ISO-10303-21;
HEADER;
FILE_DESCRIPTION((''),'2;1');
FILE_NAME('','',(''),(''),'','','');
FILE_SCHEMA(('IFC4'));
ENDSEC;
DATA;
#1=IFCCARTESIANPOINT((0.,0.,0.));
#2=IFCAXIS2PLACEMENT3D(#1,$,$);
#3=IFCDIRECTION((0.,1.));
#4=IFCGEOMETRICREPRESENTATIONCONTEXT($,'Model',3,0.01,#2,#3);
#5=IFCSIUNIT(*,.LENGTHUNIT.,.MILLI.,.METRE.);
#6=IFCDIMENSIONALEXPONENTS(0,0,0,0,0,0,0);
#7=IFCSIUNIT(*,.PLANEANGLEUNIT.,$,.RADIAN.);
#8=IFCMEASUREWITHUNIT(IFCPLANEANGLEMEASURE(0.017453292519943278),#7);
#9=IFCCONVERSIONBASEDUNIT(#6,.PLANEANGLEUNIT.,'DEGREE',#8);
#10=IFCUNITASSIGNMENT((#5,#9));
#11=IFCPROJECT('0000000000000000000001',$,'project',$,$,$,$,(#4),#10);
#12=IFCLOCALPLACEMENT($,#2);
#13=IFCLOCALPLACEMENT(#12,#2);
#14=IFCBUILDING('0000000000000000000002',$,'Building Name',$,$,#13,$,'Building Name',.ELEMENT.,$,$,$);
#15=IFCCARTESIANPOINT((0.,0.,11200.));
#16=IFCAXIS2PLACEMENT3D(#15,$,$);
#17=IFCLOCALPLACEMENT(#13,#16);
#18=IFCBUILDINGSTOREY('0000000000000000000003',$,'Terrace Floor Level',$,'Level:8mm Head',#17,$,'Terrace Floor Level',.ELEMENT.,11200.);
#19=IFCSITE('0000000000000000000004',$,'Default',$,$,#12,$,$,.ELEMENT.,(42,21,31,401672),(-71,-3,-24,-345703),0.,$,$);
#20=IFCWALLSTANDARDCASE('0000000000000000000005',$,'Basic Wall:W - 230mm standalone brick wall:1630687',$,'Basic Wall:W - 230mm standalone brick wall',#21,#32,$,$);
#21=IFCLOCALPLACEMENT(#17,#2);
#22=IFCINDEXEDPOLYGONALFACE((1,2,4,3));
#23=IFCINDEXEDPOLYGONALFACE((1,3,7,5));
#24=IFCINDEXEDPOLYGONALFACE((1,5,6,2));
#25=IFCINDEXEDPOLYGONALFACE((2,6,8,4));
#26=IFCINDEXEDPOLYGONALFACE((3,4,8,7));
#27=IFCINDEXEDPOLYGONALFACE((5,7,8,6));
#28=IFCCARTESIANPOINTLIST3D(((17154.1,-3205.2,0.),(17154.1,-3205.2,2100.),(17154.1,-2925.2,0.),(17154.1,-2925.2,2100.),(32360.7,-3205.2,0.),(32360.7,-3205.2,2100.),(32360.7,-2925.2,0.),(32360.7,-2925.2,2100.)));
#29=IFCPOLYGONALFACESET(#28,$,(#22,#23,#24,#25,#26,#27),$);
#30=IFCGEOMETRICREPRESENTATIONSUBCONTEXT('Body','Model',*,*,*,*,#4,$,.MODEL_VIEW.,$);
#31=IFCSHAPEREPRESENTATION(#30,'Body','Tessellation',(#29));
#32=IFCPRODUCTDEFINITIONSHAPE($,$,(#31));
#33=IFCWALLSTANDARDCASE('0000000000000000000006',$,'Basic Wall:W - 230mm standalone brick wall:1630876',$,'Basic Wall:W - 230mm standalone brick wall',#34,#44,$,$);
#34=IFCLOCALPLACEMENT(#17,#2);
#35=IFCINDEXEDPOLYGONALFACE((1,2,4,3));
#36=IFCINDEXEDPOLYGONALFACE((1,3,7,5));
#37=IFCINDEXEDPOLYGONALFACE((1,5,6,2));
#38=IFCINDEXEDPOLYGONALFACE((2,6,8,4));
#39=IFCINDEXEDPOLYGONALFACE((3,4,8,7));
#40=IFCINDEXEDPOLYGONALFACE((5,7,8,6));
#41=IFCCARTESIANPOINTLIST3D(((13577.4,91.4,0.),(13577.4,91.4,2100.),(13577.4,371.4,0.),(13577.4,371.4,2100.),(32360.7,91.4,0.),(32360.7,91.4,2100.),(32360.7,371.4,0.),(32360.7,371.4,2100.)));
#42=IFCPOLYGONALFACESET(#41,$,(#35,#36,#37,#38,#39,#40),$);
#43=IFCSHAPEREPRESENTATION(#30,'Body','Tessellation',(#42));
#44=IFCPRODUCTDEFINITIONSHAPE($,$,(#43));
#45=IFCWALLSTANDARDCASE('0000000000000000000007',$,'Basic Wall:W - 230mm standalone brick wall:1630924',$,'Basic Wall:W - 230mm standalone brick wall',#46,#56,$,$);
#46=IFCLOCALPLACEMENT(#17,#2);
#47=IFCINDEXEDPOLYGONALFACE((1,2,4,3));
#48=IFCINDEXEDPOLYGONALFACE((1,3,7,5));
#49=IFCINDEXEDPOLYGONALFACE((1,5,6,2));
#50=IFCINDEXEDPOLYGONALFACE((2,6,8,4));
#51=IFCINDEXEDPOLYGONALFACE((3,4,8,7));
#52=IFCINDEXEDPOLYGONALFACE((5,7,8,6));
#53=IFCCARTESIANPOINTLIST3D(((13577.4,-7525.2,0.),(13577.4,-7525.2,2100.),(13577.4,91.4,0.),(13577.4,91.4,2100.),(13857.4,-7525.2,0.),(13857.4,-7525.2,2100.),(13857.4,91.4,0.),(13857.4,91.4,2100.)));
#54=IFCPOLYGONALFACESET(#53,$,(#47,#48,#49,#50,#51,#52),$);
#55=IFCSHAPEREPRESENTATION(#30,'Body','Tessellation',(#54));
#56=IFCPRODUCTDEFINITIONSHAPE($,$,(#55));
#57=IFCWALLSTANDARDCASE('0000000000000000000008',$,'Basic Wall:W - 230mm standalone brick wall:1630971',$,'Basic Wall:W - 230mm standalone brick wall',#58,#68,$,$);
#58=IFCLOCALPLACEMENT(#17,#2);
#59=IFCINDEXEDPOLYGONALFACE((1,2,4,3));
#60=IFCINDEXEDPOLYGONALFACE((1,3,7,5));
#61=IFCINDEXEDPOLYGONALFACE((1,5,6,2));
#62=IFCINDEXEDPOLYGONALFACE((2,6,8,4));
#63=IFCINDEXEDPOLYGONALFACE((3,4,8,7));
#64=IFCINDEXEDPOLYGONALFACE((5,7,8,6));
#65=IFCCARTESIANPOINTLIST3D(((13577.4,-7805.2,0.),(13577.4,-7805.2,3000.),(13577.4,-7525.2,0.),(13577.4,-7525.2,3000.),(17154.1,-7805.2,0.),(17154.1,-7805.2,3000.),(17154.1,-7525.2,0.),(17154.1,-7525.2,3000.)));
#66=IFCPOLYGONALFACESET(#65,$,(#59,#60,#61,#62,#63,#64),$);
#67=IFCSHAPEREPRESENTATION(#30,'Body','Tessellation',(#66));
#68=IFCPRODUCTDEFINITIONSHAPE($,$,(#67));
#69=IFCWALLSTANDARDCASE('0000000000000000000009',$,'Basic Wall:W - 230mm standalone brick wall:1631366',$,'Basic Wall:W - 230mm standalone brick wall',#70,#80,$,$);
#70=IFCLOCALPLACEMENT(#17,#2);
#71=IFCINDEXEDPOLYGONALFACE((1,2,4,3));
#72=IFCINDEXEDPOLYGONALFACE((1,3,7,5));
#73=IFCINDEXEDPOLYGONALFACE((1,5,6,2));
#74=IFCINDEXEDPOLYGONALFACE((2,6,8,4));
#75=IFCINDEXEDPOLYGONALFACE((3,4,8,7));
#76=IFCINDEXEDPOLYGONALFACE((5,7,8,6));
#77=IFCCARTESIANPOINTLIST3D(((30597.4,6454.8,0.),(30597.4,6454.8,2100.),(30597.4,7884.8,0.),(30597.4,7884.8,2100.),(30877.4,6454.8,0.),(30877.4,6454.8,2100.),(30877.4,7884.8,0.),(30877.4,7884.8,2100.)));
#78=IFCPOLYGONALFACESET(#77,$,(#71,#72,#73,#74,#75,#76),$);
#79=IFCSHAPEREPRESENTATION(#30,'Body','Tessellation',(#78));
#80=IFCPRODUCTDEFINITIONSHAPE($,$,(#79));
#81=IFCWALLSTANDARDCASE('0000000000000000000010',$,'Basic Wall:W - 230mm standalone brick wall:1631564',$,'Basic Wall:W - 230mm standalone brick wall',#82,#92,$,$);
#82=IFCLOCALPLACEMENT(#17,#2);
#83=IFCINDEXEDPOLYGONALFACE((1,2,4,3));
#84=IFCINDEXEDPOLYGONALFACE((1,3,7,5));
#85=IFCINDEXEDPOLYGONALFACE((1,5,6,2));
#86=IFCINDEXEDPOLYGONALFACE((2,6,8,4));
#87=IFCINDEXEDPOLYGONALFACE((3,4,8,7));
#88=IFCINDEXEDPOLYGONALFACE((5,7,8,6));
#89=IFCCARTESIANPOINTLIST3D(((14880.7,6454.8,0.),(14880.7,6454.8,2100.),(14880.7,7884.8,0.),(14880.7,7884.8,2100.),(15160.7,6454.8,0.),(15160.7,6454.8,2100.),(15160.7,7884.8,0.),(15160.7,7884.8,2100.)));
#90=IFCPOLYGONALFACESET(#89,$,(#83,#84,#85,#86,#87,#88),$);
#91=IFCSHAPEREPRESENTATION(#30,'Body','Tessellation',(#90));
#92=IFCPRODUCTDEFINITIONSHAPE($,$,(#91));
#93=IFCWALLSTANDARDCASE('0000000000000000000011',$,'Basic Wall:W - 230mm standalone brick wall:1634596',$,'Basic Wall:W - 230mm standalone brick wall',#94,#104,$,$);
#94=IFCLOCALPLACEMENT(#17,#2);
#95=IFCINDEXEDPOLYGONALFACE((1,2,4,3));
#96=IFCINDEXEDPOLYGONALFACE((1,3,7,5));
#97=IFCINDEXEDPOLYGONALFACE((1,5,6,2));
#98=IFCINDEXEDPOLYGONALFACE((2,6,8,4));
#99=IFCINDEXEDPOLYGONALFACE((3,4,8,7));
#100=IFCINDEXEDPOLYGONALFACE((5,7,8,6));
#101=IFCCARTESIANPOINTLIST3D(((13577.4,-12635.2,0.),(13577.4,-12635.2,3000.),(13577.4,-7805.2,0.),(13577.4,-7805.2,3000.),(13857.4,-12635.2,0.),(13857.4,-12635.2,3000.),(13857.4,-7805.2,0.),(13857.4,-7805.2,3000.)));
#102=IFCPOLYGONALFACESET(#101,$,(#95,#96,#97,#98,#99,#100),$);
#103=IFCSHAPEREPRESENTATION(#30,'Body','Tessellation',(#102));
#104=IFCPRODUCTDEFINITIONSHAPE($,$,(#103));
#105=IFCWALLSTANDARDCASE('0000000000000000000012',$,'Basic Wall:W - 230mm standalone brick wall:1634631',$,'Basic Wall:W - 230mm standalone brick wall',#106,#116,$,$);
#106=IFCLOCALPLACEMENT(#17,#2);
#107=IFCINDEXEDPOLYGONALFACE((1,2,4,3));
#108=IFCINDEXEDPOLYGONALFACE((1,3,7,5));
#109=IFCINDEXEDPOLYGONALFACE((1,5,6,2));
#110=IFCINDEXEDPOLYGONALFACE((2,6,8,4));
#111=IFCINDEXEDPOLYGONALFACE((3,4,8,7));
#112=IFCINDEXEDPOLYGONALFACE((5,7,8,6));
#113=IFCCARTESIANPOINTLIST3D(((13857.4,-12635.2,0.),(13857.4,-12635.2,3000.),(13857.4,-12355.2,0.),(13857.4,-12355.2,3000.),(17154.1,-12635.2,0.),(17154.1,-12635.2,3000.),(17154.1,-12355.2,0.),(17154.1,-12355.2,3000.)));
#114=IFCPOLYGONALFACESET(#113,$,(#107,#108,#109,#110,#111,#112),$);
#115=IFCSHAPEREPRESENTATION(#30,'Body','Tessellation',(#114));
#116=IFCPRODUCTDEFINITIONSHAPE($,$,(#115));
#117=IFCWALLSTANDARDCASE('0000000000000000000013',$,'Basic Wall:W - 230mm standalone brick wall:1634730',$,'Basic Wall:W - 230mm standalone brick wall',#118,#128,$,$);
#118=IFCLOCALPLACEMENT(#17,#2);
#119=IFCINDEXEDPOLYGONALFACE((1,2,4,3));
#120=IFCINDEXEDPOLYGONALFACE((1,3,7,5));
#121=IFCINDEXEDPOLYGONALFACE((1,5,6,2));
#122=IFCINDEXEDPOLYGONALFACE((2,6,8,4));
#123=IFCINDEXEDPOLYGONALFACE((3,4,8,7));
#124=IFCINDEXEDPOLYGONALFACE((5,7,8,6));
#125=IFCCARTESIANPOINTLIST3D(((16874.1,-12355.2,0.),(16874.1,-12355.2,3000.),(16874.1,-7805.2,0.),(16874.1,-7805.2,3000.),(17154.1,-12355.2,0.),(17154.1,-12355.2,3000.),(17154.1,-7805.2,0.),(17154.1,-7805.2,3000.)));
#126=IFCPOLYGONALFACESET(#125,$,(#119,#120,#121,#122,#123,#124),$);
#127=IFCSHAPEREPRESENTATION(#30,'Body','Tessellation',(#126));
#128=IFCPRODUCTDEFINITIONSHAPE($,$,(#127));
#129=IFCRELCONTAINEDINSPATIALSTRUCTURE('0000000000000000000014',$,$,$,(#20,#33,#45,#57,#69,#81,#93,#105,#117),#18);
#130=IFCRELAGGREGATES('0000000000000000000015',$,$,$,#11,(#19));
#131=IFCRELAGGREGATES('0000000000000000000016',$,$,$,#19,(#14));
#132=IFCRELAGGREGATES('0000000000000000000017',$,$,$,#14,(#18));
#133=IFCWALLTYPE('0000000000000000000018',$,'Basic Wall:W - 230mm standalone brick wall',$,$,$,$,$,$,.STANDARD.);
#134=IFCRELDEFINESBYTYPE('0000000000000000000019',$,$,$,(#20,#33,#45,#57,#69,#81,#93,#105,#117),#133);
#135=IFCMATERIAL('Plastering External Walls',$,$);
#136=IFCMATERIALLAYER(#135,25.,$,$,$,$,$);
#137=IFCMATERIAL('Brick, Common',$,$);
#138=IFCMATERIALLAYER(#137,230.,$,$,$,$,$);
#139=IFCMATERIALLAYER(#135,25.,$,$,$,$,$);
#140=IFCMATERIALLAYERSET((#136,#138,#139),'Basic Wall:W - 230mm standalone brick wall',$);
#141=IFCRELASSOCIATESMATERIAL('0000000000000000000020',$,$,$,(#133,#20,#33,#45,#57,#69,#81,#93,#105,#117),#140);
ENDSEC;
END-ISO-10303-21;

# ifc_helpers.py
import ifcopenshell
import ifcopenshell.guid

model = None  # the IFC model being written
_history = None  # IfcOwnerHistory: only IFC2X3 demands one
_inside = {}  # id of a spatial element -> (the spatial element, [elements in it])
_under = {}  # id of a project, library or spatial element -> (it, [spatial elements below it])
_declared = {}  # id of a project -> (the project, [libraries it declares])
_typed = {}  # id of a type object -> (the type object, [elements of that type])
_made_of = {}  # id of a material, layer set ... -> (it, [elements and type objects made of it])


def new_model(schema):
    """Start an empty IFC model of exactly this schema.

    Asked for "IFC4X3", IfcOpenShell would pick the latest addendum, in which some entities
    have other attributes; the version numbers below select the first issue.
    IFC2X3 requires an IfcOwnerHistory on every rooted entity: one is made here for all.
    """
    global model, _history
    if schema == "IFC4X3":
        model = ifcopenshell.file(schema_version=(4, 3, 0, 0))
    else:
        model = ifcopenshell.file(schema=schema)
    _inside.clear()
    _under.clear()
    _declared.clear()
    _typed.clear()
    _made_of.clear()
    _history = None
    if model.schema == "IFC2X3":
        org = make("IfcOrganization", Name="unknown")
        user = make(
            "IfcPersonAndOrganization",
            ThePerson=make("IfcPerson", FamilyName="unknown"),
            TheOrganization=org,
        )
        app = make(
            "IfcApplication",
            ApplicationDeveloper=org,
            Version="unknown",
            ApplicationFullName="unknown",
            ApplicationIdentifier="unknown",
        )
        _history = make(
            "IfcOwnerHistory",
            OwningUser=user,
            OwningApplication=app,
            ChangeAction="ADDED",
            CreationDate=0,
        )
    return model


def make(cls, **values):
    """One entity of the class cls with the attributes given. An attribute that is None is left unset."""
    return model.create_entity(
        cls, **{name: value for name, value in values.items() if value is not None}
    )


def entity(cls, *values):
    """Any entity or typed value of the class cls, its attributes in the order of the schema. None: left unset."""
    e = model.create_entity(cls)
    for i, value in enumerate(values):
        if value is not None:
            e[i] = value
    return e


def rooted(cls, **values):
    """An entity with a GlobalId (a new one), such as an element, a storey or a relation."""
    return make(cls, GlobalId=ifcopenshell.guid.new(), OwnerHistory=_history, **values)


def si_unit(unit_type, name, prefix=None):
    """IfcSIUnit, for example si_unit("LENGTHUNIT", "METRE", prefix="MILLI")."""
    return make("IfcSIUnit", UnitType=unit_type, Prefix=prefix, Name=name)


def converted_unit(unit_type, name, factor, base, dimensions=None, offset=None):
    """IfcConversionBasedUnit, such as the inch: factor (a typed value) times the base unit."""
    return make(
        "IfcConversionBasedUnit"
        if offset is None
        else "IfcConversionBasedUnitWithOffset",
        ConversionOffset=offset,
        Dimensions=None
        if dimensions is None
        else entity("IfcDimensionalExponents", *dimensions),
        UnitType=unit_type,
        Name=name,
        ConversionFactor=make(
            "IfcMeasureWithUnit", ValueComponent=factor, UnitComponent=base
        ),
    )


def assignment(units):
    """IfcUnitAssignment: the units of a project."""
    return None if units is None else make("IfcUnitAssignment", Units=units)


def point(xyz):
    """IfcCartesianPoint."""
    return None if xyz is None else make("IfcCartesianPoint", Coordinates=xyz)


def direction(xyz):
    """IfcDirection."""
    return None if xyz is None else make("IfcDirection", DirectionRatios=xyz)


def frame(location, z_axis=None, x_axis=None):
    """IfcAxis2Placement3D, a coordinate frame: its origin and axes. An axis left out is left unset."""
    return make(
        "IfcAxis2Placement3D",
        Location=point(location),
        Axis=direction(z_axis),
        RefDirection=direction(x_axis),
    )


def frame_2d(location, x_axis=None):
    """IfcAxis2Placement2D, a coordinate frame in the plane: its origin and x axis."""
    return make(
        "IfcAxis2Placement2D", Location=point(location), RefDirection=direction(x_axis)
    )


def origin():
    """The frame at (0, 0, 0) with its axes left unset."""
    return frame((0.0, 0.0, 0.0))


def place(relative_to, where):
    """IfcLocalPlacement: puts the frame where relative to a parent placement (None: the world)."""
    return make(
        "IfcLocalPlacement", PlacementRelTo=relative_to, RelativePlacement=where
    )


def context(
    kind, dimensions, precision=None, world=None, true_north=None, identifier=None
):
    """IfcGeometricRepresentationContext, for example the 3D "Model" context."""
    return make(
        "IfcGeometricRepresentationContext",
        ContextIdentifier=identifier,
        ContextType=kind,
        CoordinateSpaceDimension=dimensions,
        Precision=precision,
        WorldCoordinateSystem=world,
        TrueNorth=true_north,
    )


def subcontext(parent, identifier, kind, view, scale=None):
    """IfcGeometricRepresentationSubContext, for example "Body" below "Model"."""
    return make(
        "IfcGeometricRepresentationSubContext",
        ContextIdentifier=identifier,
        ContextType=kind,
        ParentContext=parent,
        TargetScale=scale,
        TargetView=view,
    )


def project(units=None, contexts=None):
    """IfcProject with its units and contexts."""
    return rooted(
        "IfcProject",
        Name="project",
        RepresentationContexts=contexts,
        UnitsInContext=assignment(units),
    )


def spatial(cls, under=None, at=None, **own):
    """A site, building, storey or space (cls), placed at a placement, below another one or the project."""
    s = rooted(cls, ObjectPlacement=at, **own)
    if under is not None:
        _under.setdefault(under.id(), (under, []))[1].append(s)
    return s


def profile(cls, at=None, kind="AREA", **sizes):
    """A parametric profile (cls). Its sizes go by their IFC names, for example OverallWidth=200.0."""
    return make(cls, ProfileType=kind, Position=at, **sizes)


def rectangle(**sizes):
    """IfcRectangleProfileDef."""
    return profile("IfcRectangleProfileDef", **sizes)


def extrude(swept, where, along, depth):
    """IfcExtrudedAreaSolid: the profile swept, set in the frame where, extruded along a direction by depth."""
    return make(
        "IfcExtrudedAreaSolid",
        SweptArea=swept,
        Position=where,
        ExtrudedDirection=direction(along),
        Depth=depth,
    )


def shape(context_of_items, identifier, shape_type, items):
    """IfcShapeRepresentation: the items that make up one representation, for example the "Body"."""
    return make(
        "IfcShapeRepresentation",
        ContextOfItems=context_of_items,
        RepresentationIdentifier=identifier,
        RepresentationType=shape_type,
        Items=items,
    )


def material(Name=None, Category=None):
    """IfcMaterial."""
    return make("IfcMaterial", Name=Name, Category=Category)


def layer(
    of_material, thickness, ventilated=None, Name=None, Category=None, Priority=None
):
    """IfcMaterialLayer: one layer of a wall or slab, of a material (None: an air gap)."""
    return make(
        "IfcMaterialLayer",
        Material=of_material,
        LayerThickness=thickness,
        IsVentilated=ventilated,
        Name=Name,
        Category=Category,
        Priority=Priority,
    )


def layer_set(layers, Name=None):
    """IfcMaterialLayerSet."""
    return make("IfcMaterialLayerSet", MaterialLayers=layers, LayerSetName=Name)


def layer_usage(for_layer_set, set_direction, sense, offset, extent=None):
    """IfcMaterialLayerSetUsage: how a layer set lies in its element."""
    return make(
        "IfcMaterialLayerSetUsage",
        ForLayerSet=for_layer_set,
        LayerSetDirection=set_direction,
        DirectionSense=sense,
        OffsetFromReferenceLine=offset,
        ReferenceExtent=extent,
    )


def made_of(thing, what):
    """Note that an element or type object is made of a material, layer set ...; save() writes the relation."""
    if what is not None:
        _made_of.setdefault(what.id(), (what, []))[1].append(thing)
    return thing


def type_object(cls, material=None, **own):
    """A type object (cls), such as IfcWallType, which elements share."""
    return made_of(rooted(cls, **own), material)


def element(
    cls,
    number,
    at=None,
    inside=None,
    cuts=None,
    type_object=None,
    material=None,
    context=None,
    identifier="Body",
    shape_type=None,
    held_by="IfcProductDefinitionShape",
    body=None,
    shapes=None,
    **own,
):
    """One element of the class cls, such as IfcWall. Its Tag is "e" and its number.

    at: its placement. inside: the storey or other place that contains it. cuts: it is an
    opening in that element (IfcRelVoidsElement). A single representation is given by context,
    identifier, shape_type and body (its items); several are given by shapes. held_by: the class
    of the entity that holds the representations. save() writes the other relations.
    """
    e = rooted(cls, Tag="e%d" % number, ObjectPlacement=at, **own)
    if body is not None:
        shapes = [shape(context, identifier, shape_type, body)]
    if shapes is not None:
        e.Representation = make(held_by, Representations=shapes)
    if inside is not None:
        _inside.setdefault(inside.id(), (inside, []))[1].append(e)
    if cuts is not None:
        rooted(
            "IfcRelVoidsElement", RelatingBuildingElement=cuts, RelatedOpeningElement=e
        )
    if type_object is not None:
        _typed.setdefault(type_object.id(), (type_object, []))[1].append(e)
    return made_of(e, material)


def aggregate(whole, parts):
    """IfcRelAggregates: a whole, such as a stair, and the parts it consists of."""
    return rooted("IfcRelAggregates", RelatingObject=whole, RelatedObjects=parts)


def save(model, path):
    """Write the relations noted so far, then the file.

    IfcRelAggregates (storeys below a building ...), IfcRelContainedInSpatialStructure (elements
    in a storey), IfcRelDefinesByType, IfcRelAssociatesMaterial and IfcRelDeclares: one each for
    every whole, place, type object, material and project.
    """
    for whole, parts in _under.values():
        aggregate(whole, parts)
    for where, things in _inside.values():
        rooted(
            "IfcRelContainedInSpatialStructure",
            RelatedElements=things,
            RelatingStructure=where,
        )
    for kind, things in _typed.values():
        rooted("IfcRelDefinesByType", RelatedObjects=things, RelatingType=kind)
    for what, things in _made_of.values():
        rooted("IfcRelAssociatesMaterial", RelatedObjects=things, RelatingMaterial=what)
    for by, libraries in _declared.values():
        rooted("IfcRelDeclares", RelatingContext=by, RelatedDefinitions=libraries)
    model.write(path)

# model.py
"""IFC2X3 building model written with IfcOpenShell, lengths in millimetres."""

from ifc_helpers import new_model, entity, si_unit, converted_unit, direction, frame, frame_2d, origin, place, context, subcontext, project, spatial, rectangle, extrude, material, layer, layer_set, layer_usage, type_object, element, save


model = new_model("IFC2X3")

# Units and contexts
model_context = context("Model", 3, precision=0.01, world=origin(), true_north=direction((0.0, 1.0)))
body_context = subcontext(model_context, "Body", "Model", "MODEL_VIEW")
ifc_project = project(units=[si_unit("LENGTHUNIT", "METRE", prefix="MILLI"), converted_unit("PLANEANGLEUNIT", "DEGREE", entity("IfcPlaneAngleMeasure", 0.017453292519943278), si_unit("PLANEANGLEUNIT", "RADIAN"), dimensions=[0, 0, 0, 0, 0, 0, 0])], contexts=[model_context])

# Site, building, storey
site_placement = place(None, origin())
site = spatial("IfcSite", under=ifc_project, at=site_placement, Name="Default", CompositionType="ELEMENT", RefLatitude=(42, 21, 31, 401672), RefLongitude=(-71, -3, -24, -345703), RefElevation=0.0)
building_placement = place(site_placement, origin())
building = spatial("IfcBuilding", under=site, at=building_placement, Name="Building Name", LongName="Building Name", CompositionType="ELEMENT")
storey_placement = place(building_placement, frame((0.0, 0.0, 11200.0)))
storey = spatial("IfcBuildingStorey", under=building, at=storey_placement, Name="Terrace Floor Level", ObjectType="Level:8mm Head", LongName="Terrace Floor Level", CompositionType="ELEMENT", Elevation=11200.0)

# Walls
ifc_material_1 = material(Name="Plastering External Walls")
ifc_layer_1 = layer(ifc_material_1, 25.0)
ifc_material_2 = material(Name="Brick, Common")
ifc_layer_2 = layer(ifc_material_2, 230.0)
ifc_layer_3 = layer(ifc_material_1, 25.0)
ifc_layer_set = layer_set([ifc_layer_1, ifc_layer_2, ifc_layer_3], Name="Basic Wall:W - 230mm standalone brick wall")
wall_type = type_object("IfcWallType", Name="Basic Wall:W - 230mm standalone brick wall", PredefinedType="STANDARD", material=ifc_layer_set)
ifc_layer_usage_1 = layer_usage(ifc_layer_set, "AXIS2", "NEGATIVE", 140.0)
wall_1_placement = place(storey_placement, frame((17154.1, -3065.2, 0.0)))
element("IfcWallStandardCase", 1, at=wall_1_placement, inside=storey, type_object=wall_type, material=ifc_layer_usage_1, Name="Basic Wall:W - 230mm standalone brick wall:1630687", ObjectType="Basic Wall:W - 230mm standalone brick wall", context=body_context, shape_type="SweptSolid", body=[
    extrude(rectangle(XDim=15206.7, YDim=280.0, at=frame_2d((7603.3, 0.0), x_axis=(-1.0, 0.0))), origin(), (0.0, 0.0, 1.0), 2100.0),
])
ifc_layer_usage_2 = layer_usage(ifc_layer_set, "AXIS2", "NEGATIVE", 140.0)
wall_2_placement = place(storey_placement, frame((32360.7, 231.4, 0.0), z_axis=(0.0, 0.0, 1.0), x_axis=(-1.0, 0.0, 0.0)))
element("IfcWallStandardCase", 2, at=wall_2_placement, inside=storey, type_object=wall_type, material=ifc_layer_usage_2, Name="Basic Wall:W - 230mm standalone brick wall:1630876", ObjectType="Basic Wall:W - 230mm standalone brick wall", context=body_context, shape_type="SweptSolid", body=[
    extrude(rectangle(XDim=18783.3, YDim=280.0, at=frame_2d((9391.7, 0.0), x_axis=(-1.0, 0.0))), origin(), (0.0, 0.0, 1.0), 2100.0),
])
ifc_layer_usage_3 = layer_usage(ifc_layer_set, "AXIS2", "NEGATIVE", 140.0)
wall_3_placement = place(storey_placement, frame((13717.4, 91.4, 0.0), z_axis=(0.0, 0.0, 1.0), x_axis=(0.0, -1.0, 0.0)))
element("IfcWallStandardCase", 3, at=wall_3_placement, inside=storey, type_object=wall_type, material=ifc_layer_usage_3, Name="Basic Wall:W - 230mm standalone brick wall:1630924", ObjectType="Basic Wall:W - 230mm standalone brick wall", context=body_context, shape_type="SweptSolid", body=[
    extrude(rectangle(XDim=7616.7, YDim=280.0, at=frame_2d((3808.3, 0.0), x_axis=(-1.0, 0.0))), origin(), (0.0, 0.0, 1.0), 2100.0),
])
ifc_layer_usage_4 = layer_usage(ifc_layer_set, "AXIS2", "NEGATIVE", 140.0)
wall_4_placement = place(storey_placement, frame((13577.4, -7665.2, 0.0)))
element("IfcWallStandardCase", 4, at=wall_4_placement, inside=storey, type_object=wall_type, material=ifc_layer_usage_4, Name="Basic Wall:W - 230mm standalone brick wall:1630971", ObjectType="Basic Wall:W - 230mm standalone brick wall", context=body_context, shape_type="SweptSolid", body=[
    extrude(rectangle(XDim=3576.7, YDim=280.0, at=frame_2d((1788.3, 0.0), x_axis=(-1.0, 0.0))), origin(), (0.0, 0.0, 1.0), 3000.0),
])
ifc_layer_usage_5 = layer_usage(ifc_layer_set, "AXIS2", "NEGATIVE", 140.0)
wall_5_placement = place(storey_placement, frame((30737.4, 6454.8, 0.0), z_axis=(0.0, 0.0, 1.0), x_axis=(0.0, 1.0, 0.0)))
element("IfcWallStandardCase", 5, at=wall_5_placement, inside=storey, type_object=wall_type, material=ifc_layer_usage_5, Name="Basic Wall:W - 230mm standalone brick wall:1631366", ObjectType="Basic Wall:W - 230mm standalone brick wall", context=body_context, shape_type="SweptSolid", body=[
    extrude(rectangle(XDim=1430.0, YDim=280.0, at=frame_2d((715.0, 0.0), x_axis=(-1.0, 0.0))), origin(), (0.0, 0.0, 1.0), 2100.0),
])
ifc_layer_usage_6 = layer_usage(ifc_layer_set, "AXIS2", "NEGATIVE", 140.0)
wall_6_placement = place(storey_placement, frame((15020.7, 6454.8, 0.0), z_axis=(0.0, 0.0, 1.0), x_axis=(0.0, 1.0, 0.0)))
element("IfcWallStandardCase", 6, at=wall_6_placement, inside=storey, type_object=wall_type, material=ifc_layer_usage_6, Name="Basic Wall:W - 230mm standalone brick wall:1631564", ObjectType="Basic Wall:W - 230mm standalone brick wall", context=body_context, shape_type="SweptSolid", body=[
    extrude(rectangle(XDim=1430.0, YDim=280.0, at=frame_2d((715.0, 0.0), x_axis=(-1.0, 0.0))), origin(), (0.0, 0.0, 1.0), 2100.0),
])
ifc_layer_usage_7 = layer_usage(ifc_layer_set, "AXIS2", "NEGATIVE", 140.0)
wall_7_placement = place(storey_placement, frame((13717.4, -7805.2, 0.0), z_axis=(0.0, 0.0, 1.0), x_axis=(0.0, -1.0, 0.0)))
element("IfcWallStandardCase", 7, at=wall_7_placement, inside=storey, type_object=wall_type, material=ifc_layer_usage_7, Name="Basic Wall:W - 230mm standalone brick wall:1634596", ObjectType="Basic Wall:W - 230mm standalone brick wall", context=body_context, shape_type="SweptSolid", body=[
    extrude(rectangle(XDim=4830.0, YDim=280.0, at=frame_2d((2415.0, 0.0), x_axis=(-1.0, 0.0))), origin(), (0.0, 0.0, 1.0), 3000.0),
])
ifc_layer_usage_8 = layer_usage(ifc_layer_set, "AXIS2", "NEGATIVE", 140.0)
wall_8_placement = place(storey_placement, frame((13857.4, -12495.2, 0.0)))
element("IfcWallStandardCase", 8, at=wall_8_placement, inside=storey, type_object=wall_type, material=ifc_layer_usage_8, Name="Basic Wall:W - 230mm standalone brick wall:1634631", ObjectType="Basic Wall:W - 230mm standalone brick wall", context=body_context, shape_type="SweptSolid", body=[
    extrude(rectangle(XDim=3296.7, YDim=280.0, at=frame_2d((1648.3, 0.0), x_axis=(-1.0, 0.0))), origin(), (0.0, 0.0, 1.0), 3000.0),
])
ifc_layer_usage_9 = layer_usage(ifc_layer_set, "AXIS2", "NEGATIVE", 140.0)
wall_9_placement = place(storey_placement, frame((17014.1, -12355.2, 0.0), z_axis=(0.0, 0.0, 1.0), x_axis=(0.0, 1.0, 0.0)))
element("IfcWallStandardCase", 9, at=wall_9_placement, inside=storey, type_object=wall_type, material=ifc_layer_usage_9, Name="Basic Wall:W - 230mm standalone brick wall:1634730", ObjectType="Basic Wall:W - 230mm standalone brick wall", context=body_context, shape_type="SweptSolid", body=[
    extrude(rectangle(XDim=4550.0, YDim=280.0, at=frame_2d((2275.0, 0.0), x_axis=(-1.0, 0.0))), origin(), (0.0, 0.0, 1.0), 3000.0),
])

save(model, "model.ifc")
